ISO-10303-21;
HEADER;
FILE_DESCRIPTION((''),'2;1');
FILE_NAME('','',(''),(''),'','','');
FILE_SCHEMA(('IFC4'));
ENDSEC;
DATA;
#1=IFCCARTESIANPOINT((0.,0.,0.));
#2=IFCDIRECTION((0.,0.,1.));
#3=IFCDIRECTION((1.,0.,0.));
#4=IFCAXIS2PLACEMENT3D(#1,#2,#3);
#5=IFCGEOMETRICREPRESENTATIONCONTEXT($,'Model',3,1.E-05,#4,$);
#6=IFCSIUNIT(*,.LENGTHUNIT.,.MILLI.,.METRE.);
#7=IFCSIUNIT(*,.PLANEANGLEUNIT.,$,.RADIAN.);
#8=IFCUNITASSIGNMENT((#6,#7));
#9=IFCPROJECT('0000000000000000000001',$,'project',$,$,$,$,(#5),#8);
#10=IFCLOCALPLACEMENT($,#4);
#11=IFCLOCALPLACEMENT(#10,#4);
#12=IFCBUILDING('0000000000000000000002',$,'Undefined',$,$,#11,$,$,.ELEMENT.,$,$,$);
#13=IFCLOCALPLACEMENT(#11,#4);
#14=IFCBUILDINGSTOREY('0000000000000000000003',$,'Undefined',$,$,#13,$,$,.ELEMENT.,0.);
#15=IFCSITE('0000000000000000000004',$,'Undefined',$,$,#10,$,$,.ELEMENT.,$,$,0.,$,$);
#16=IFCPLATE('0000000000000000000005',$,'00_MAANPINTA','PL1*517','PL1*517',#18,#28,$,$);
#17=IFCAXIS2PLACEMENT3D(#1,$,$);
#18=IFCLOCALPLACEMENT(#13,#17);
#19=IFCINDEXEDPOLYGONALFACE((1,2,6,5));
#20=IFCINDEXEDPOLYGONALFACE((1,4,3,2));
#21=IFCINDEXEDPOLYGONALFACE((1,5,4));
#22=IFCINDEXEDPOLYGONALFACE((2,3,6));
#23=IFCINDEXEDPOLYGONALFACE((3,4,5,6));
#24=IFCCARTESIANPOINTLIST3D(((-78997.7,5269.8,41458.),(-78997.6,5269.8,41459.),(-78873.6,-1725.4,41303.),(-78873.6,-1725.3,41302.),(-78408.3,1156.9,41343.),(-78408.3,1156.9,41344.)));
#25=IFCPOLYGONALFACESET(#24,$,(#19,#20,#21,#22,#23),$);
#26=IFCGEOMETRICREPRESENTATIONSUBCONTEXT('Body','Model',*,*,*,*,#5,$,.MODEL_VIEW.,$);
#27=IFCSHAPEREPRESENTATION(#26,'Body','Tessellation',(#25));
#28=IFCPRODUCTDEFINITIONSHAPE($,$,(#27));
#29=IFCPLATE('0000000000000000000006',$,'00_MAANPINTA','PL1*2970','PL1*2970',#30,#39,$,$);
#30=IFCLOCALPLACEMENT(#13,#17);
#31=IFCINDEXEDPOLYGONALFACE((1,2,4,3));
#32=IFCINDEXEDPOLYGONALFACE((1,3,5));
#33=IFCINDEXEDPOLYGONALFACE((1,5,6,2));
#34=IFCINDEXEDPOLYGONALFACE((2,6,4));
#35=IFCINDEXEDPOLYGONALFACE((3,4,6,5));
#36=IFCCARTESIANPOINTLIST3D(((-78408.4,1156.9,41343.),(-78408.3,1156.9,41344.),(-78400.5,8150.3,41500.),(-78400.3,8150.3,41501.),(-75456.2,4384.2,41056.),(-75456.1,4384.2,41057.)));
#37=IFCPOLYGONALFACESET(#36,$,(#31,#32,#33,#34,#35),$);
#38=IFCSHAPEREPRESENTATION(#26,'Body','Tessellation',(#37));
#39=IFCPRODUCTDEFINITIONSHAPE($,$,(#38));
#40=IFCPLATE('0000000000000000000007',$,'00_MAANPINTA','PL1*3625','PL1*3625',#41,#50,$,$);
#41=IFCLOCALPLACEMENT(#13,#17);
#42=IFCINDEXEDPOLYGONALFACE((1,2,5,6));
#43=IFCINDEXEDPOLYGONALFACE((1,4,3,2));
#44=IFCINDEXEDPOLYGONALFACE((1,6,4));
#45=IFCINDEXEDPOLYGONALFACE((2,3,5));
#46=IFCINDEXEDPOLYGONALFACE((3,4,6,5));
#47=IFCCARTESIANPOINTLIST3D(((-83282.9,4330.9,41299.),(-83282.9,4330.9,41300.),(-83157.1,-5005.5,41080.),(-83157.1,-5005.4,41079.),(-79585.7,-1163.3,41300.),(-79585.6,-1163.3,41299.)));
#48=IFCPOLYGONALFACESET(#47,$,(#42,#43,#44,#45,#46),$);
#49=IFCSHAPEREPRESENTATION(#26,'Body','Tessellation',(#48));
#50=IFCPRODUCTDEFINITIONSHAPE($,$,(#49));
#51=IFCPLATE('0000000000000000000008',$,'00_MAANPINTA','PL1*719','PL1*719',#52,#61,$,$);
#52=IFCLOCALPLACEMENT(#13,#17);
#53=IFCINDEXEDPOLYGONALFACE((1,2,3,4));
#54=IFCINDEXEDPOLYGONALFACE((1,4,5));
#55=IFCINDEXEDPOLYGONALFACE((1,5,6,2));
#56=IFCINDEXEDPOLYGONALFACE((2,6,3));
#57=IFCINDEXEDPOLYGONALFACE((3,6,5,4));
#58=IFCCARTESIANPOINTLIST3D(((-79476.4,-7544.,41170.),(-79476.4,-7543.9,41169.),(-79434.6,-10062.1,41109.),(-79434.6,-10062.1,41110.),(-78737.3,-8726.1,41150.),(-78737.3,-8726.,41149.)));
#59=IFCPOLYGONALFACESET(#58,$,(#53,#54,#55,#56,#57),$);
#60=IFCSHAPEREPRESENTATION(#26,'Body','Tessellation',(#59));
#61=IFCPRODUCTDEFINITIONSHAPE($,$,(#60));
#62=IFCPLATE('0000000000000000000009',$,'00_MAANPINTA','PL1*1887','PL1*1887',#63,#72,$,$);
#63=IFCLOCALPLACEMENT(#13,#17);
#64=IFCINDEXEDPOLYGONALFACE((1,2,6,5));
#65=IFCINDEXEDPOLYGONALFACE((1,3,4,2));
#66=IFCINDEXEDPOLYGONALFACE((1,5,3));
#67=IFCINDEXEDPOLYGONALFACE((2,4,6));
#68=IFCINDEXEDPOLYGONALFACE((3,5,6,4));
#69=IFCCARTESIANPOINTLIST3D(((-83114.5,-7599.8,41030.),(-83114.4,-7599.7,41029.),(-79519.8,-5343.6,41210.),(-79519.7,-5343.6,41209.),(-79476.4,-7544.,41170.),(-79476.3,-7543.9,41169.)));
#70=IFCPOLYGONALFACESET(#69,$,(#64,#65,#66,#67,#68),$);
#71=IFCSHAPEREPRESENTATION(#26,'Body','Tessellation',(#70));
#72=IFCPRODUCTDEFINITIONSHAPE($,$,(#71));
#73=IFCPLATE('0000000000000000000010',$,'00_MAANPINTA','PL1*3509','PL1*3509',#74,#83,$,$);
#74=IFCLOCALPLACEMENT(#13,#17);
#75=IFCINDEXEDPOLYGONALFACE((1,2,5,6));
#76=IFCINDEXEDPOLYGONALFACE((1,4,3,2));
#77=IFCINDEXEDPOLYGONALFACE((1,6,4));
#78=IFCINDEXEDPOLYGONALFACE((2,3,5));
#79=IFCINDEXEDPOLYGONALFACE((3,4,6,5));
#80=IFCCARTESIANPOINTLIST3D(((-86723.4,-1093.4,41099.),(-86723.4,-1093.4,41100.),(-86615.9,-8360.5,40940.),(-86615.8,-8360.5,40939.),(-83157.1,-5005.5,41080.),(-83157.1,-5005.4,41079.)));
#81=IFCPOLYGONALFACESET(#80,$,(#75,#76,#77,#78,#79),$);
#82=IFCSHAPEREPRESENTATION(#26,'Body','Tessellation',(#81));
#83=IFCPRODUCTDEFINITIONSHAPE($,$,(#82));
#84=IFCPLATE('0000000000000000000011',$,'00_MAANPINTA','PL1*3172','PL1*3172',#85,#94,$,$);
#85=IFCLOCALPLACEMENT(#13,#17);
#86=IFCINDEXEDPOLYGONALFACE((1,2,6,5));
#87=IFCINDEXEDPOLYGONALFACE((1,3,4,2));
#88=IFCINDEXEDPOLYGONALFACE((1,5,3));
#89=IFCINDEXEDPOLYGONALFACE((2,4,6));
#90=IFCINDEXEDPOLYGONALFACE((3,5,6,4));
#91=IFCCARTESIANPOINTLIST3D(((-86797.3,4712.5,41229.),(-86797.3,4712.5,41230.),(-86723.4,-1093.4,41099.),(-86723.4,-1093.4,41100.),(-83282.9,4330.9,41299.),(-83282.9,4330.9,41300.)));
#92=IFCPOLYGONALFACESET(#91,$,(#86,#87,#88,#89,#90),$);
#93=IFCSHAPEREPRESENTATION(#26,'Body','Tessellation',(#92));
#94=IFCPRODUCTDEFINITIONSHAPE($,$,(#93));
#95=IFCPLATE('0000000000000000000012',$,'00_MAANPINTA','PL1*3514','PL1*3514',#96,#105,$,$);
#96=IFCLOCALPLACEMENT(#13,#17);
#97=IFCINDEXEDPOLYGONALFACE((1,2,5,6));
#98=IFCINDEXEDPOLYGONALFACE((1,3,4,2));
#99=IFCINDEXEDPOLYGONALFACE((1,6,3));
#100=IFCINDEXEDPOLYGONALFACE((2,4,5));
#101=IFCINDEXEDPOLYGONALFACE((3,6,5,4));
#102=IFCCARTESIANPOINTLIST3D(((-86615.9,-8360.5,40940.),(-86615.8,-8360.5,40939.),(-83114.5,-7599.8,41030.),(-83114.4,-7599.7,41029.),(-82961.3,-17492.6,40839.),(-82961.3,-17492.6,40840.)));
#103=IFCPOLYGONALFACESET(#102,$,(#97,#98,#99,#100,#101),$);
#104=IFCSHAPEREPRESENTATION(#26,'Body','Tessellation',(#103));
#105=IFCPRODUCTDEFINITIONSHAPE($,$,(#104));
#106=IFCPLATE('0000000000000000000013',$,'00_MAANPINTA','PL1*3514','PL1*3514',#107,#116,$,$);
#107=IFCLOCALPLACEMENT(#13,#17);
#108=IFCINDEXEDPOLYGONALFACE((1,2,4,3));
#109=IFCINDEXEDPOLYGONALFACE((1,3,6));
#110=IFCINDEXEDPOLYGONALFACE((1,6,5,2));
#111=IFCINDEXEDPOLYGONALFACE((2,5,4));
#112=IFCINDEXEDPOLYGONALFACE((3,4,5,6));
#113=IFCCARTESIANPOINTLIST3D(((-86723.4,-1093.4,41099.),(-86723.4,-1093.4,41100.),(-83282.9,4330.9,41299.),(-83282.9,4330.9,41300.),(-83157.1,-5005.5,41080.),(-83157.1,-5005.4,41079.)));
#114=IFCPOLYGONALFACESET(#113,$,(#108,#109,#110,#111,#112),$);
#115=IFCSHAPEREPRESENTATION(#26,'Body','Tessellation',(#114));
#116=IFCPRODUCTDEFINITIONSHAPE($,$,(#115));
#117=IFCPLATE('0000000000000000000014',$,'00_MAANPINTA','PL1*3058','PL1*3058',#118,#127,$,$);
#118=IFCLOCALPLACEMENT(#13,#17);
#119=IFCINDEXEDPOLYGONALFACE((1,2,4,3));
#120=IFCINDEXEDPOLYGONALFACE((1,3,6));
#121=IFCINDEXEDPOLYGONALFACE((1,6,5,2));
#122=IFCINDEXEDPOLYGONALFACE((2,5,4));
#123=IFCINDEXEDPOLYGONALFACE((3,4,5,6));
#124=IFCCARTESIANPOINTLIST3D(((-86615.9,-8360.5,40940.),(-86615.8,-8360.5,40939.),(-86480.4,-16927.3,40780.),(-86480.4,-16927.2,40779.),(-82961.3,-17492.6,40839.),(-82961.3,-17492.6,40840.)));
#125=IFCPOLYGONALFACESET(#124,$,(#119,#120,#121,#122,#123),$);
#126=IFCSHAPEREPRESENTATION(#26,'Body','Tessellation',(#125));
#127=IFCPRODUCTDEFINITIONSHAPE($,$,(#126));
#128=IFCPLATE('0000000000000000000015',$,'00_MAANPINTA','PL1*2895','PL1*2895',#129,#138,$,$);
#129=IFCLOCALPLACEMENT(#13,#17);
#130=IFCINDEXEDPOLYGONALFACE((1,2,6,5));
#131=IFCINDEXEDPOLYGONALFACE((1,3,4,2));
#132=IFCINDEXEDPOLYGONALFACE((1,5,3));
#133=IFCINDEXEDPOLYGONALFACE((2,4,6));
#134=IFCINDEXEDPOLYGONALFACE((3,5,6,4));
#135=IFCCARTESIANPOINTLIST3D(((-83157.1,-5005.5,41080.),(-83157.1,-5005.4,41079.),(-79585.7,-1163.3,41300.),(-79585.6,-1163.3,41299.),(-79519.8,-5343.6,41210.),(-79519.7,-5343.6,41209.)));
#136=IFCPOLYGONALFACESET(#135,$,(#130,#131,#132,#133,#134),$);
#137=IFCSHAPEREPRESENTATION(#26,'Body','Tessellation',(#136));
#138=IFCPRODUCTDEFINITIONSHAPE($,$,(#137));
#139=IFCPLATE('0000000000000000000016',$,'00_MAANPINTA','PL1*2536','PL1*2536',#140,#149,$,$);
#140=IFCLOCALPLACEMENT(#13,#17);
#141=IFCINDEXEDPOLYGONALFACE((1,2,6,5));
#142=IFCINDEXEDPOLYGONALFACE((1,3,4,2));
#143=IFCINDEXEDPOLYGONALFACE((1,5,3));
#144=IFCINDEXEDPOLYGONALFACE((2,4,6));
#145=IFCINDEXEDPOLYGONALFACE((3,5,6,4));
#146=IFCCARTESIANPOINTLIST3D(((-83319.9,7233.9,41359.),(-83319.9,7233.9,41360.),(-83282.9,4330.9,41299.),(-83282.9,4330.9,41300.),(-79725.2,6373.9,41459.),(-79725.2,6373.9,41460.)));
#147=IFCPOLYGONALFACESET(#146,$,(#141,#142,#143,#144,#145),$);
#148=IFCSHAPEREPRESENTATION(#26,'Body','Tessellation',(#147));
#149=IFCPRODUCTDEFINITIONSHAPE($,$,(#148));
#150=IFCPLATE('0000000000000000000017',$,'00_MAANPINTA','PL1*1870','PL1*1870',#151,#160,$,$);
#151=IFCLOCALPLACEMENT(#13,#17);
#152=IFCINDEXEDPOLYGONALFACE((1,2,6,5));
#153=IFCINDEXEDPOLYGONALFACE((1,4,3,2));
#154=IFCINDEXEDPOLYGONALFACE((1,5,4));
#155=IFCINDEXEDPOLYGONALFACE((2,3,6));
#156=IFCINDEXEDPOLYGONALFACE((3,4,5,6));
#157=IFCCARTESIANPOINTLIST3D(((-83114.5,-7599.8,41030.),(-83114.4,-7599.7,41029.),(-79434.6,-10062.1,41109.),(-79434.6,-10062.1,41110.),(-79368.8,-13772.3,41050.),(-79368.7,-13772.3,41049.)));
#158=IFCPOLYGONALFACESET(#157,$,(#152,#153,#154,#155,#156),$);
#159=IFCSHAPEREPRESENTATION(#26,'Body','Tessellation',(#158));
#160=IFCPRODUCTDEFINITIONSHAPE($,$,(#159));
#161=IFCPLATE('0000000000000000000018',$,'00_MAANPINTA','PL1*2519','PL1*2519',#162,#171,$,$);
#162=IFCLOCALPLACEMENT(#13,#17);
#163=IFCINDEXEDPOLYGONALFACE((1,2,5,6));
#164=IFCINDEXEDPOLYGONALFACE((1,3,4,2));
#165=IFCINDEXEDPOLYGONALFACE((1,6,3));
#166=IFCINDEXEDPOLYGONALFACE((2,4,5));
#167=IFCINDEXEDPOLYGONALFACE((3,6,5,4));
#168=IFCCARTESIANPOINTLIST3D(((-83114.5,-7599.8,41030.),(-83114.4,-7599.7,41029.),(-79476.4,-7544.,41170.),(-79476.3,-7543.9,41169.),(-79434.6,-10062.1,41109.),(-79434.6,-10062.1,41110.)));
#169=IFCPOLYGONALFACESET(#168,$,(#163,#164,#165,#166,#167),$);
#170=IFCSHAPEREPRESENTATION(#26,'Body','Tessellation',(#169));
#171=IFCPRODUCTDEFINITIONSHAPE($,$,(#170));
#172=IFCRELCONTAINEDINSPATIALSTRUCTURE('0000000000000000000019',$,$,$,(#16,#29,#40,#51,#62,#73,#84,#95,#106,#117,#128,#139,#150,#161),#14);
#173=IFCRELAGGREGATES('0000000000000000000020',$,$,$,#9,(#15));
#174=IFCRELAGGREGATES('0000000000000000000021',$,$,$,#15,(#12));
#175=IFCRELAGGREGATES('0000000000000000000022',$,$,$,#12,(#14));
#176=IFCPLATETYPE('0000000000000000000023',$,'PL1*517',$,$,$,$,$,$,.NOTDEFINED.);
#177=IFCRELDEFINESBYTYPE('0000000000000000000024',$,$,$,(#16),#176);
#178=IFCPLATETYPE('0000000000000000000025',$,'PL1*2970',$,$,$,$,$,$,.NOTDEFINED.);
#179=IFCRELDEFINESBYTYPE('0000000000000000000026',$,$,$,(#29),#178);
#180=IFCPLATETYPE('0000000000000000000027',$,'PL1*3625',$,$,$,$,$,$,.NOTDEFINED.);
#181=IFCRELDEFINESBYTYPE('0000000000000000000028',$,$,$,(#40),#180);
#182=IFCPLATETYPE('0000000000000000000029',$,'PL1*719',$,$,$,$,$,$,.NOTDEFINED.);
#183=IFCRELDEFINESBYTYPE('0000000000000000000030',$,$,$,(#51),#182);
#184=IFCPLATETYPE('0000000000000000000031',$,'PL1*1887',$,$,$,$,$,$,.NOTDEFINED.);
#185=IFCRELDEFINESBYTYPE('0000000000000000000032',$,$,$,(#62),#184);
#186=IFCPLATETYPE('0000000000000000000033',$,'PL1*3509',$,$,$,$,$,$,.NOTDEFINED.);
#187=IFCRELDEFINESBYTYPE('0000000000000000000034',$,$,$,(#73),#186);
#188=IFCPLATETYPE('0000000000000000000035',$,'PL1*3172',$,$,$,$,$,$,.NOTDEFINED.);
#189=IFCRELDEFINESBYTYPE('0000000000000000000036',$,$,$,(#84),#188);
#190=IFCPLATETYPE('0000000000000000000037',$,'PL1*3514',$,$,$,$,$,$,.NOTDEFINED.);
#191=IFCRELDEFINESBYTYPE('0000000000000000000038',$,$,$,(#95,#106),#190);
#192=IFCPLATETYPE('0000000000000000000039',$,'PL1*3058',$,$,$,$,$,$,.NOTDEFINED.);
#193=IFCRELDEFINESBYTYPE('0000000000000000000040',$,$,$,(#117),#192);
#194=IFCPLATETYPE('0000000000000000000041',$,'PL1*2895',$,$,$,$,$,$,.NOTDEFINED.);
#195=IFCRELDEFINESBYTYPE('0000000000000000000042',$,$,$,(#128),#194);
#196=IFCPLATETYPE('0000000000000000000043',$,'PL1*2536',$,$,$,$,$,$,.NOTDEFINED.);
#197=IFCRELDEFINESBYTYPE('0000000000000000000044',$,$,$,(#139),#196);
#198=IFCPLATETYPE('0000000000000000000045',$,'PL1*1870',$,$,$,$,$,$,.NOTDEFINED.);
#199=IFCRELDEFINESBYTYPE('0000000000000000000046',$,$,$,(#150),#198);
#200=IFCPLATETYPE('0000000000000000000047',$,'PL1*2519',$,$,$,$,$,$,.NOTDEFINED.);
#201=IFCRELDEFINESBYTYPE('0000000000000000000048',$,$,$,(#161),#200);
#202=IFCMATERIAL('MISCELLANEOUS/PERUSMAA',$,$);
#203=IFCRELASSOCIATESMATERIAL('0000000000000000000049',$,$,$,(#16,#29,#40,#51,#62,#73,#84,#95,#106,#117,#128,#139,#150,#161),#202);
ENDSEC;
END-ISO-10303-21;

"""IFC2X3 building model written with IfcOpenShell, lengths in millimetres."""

from ifc_helpers import new_model, si_unit, frame, origin_with_axes, place, context, subcontext, project, spatial, polyline, outline, extrude, material, type_object, element, save


model = new_model("IFC2X3")

# Units and contexts
model_context = context("Model", 3, precision=1e-05, world=origin_with_axes())
body_context = subcontext(model_context, "Body", "Model", "MODEL_VIEW")
ifc_project = project(units=[si_unit("LENGTHUNIT", "METRE", prefix="MILLI"), si_unit("PLANEANGLEUNIT", "RADIAN")], contexts=[model_context])

# Site, building, storey
site_placement = place(None, origin_with_axes())
site = spatial("IfcSite", under=ifc_project, at=site_placement, Name="Undefined", CompositionType="ELEMENT", RefElevation=0.0)
building_placement = place(site_placement, origin_with_axes())
building = spatial("IfcBuilding", under=site, at=building_placement, Name="Undefined", CompositionType="ELEMENT")
storey_placement = place(building_placement, origin_with_axes())
storey = spatial("IfcBuildingStorey", under=building, at=storey_placement, Name="Undefined", CompositionType="ELEMENT", Elevation=0.0)

# Plates
ifc_material = material(Name="MISCELLANEOUS/PERUSMAA")
plate_type_1 = type_object("IfcPlateType", Name="PL1*517", PredefinedType="NOTDEFINED")
plate_1_placement = place(storey_placement, frame((-78873.6, -1725.4, 41302.5), z_axis=(-0.045019, 0.021475, -0.998755), x_axis=(-0.017726, 0.999594, 0.022292)))
element("IfcPlate", 1, at=plate_1_placement, inside=storey, type_object=plate_type_1, material=ifc_material, Name="00_MAANPINTA", Description="PL1*517", ObjectType="PL1*517", context=body_context, shape_type="SweptSolid", body=[
    extrude(outline(polyline([(0.0, 0.0), (6998.0, 0.0), (2873.8, 516.9), (0.0, 0.0)])), frame((0.0, 0.0, -0.5), z_axis=(0.0, 0.0, 1.0), x_axis=(1.0, 0.0, 0.0)), (0.0, 0.0, 1.0), 1.0),
])
plate_type_2 = type_object("IfcPlateType", Name="PL1*2970", PredefinedType="NOTDEFINED")
plate_2_placement = place(storey_placement, frame((-75456.2, 4384.2, 41056.5), z_axis=(-0.120984, 0.022417, -0.992401), x_axis=(-0.673509, -0.736273, 0.065476)))
element("IfcPlate", 2, at=plate_2_placement, inside=storey, type_object=plate_type_2, material=ifc_material, Name="00_MAANPINTA", Description="PL1*2970", ObjectType="PL1*2970", context=body_context, shape_type="SweptSolid", body=[
    extrude(outline(polyline([(0.0, 0.0), (4383.3, 0.0), (-760.9, 4740.3), (0.0, 0.0)])), frame((0.0, 0.0, -0.5), z_axis=(0.0, 0.0, 1.0), x_axis=(1.0, 0.0, 0.0)), (0.0, 0.0, 1.0), 1.0),
])
plate_type_3 = type_object("IfcPlateType", Name="PL1*3625", PredefinedType="NOTDEFINED")
plate_3_placement = place(storey_placement, frame((-83282.9, 4330.9, 41299.5), z_axis=(0.035699, 0.024023, -0.999074), x_axis=(0.558298, -0.829641, 0.0)))
element("IfcPlate", 3, at=plate_3_placement, inside=storey, type_object=plate_type_3, material=ifc_material, Name="00_MAANPINTA", Description="PL1*3625", ObjectType="PL1*3625", context=body_context, shape_type="SweptSolid", body=[
    extrude(outline(polyline([(0.0, 0.0), (6622.4, 0.0), (7816.1, 5112.8), (0.0, 0.0)])), frame((0.0, 0.0, -0.5), z_axis=(0.0, 0.0, 1.0), x_axis=(1.0, 0.0, 0.0)), (0.0, 0.0, 1.0), 1.0),
])
plate_type_4 = type_object("IfcPlateType", Name="PL1*719", PredefinedType="NOTDEFINED")
plate_4_placement = place(storey_placement, frame((-79476.4, -7543.9, 41169.5), z_axis=(0.011346, 0.024007, -0.999647), x_axis=(0.530086, -0.847822, -0.014344)))
element("IfcPlate", 4, at=plate_4_placement, inside=storey, type_object=plate_type_4, material=ifc_material, Name="00_MAANPINTA", Description="PL1*719", ObjectType="PL1*719", context=body_context, shape_type="SweptSolid", body=[
    extrude(outline(polyline([(0.0, 0.0), (1394.3, 0.0), (2157.9, 1299.9), (0.0, 0.0)])), frame((0.0, 0.0, -0.5), z_axis=(0.0, 0.0, 1.0), x_axis=(1.0, 0.0, 0.0)), (0.0, 0.0, 1.0), 1.0),
])
plate_type_5 = type_object("IfcPlateType", Name="PL1*1887", PredefinedType="NOTDEFINED")
plate_5_placement = place(storey_placement, frame((-79519.7, -5343.6, 41209.5), z_axis=(0.038157, 0.018915, -0.999093), x_axis=(0.019718, -0.99964, -0.018172)))
element("IfcPlate", 5, at=plate_5_placement, inside=storey, type_object=plate_type_5, material=ifc_material, Name="00_MAANPINTA", Description="PL1*1887", ObjectType="PL1*1887", context=body_context, shape_type="SweptSolid", body=[
    extrude(outline(polyline([(0.0, 0.0), (2201.1, 0.0), (2187.7, 3641.2), (0.0, 0.0)])), frame((0.0, 0.0, -0.5), z_axis=(0.0, 0.0, 1.0), x_axis=(1.0, 0.0, 0.0)), (0.0, 0.0, 1.0), 1.0),
])
plate_type_6 = type_object("IfcPlateType", Name="PL1*3509", PredefinedType="NOTDEFINED")
plate_6_placement = place(storey_placement, frame((-86615.9, -8360.5, 40939.5), z_axis=(0.018841, 0.022287, -0.999574), x_axis=(-0.014798, 0.999648, 0.022009)))
element("IfcPlate", 6, at=plate_6_placement, inside=storey, type_object=plate_type_6, material=ifc_material, Name="00_MAANPINTA", Description="PL1*3509", ObjectType="PL1*3509", context=body_context, shape_type="SweptSolid", body=[
    extrude(outline(polyline([(0.0, 0.0), (7269.6, 0.0), (3305.7, 3508.7), (0.0, 0.0)])), frame((0.0, 0.0, -0.5), z_axis=(0.0, 0.0, 1.0), x_axis=(1.0, 0.0, 0.0)), (0.0, 0.0, 1.0), 1.0),
])
plate_type_7 = type_object("IfcPlateType", Name="PL1*3172", PredefinedType="NOTDEFINED")
plate_7_placement = place(storey_placement, frame((-86723.4, -1093.4, 41099.5), z_axis=(0.022369, 0.022664, -0.999493), x_axis=(-0.012723, 0.999669, 0.022384)))
element("IfcPlate", 7, at=plate_7_placement, inside=storey, type_object=plate_type_7, material=ifc_material, Name="00_MAANPINTA", Description="PL1*3172", ObjectType="PL1*3172", context=body_context, shape_type="SweptSolid", body=[
    extrude(outline(polyline([(0.0, 0.0), (5807.8, 0.0), (5383.2, 3510.1), (0.0, 0.0)])), frame((0.0, 0.0, -0.5), z_axis=(0.0, 0.0, 1.0), x_axis=(1.0, 0.0, 0.0)), (0.0, 0.0, 1.0), 1.0),
])
plate_type_8 = type_object("IfcPlateType", Name="PL1*3514", PredefinedType="NOTDEFINED")
plate_8_placement = place(storey_placement, frame((-86615.9, -8360.5, 40939.5), z_axis=(0.02145, 0.01953, -0.999579), x_axis=(0.976894, 0.212244, 0.02511)))
element("IfcPlate", 8, at=plate_8_placement, inside=storey, type_object=plate_type_8, material=ifc_material, Name="00_MAANPINTA", Description="PL1*3514", ObjectType="PL1*3514", context=body_context, shape_type="SweptSolid", body=[
    extrude(outline(polyline([(0.0, 0.0), (3584.2, 0.0), (1629.4, 9700.8), (0.0, 0.0)])), frame((0.0, 0.0, -0.5), z_axis=(0.0, 0.0, 1.0), x_axis=(1.0, 0.0, 0.0)), (0.0, 0.0, 1.0), 1.0),
])
plate_9_placement = place(storey_placement, frame((-83282.9, 4330.9, 41299.5), z_axis=(0.020533, 0.023829, -0.999505), x_axis=(0.013474, -0.999632, -0.023555)))
element("IfcPlate", 9, at=plate_9_placement, inside=storey, type_object=plate_type_8, material=ifc_material, Name="00_MAANPINTA", Description="PL1*3514", ObjectType="PL1*3514", context=body_context, shape_type="SweptSolid", body=[
    extrude(outline(polyline([(0.0, 0.0), (9339.8, 0.0), (5380.7, 3514.1), (0.0, 0.0)])), frame((0.0, 0.0, -0.5), z_axis=(0.0, 0.0, 1.0), x_axis=(1.0, 0.0, 0.0)), (0.0, 0.0, 1.0), 1.0),
])
plate_type_9 = type_object("IfcPlateType", Name="PL1*3058", PredefinedType="NOTDEFINED")
plate_10_placement = place(storey_placement, frame((-86615.9, -8360.5, 40939.5), z_axis=(0.020094, 0.018987, -0.999618), x_axis=(0.371524, -0.928368, -0.010166)))
element("IfcPlate", 10, at=plate_10_placement, inside=storey, type_object=plate_type_9, material=ifc_material, Name="00_MAANPINTA", Description="PL1*3058", ObjectType="PL1*3058", context=body_context, shape_type="SweptSolid", body=[
    extrude(outline(polyline([(0.0, 0.0), (9836.7, 0.0), (8005.1, 3058.1), (0.0, 0.0)])), frame((0.0, 0.0, -0.5), z_axis=(0.0, 0.0, 1.0), x_axis=(1.0, 0.0, 0.0)), (0.0, 0.0, 1.0), 1.0),
])
plate_type_10 = type_object("IfcPlateType", Name="PL1*2895", PredefinedType="NOTDEFINED")
plate_11_placement = place(storey_placement, frame((-79585.7, -1163.3, 41299.5), z_axis=(0.037761, 0.022104, -0.999042), x_axis=(0.015762, -0.999644, -0.021522)))
element("IfcPlate", 11, at=plate_11_placement, inside=storey, type_object=plate_type_10, material=ifc_material, Name="00_MAANPINTA", Description="PL1*2895", ObjectType="PL1*2895", context=body_context, shape_type="SweptSolid", body=[
    extrude(outline(polyline([(0.0, 0.0), (4181.8, 0.0), (3789.2, 3634.2), (0.0, 0.0)])), frame((0.0, 0.0, -0.5), z_axis=(0.0, 0.0, 1.0), x_axis=(1.0, 0.0, 0.0)), (0.0, 0.0, 1.0), 1.0),
])
plate_type_11 = type_object("IfcPlateType", Name="PL1*2536", PredefinedType="NOTDEFINED")
plate_12_placement = place(storey_placement, frame((-83282.9, 4330.9, 41299.5), z_axis=(0.032838, 0.021071, -0.999239), x_axis=(-0.012723, 0.999706, 0.020663)))
element("IfcPlate", 12, at=plate_12_placement, inside=storey, type_object=plate_type_11, material=ifc_material, Name="00_MAANPINTA", Description="PL1*2536", ObjectType="PL1*2536", context=body_context, shape_type="SweptSolid", body=[
    extrude(outline(polyline([(0.0, 0.0), (2903.8, 0.0), (2000.4, 3585.4), (0.0, 0.0)])), frame((0.0, 0.0, -0.5), z_axis=(0.0, 0.0, 1.0), x_axis=(1.0, 0.0, 0.0)), (0.0, 0.0, 1.0), 1.0),
])
plate_type_12 = type_object("IfcPlateType", Name="PL1*1870", PredefinedType="NOTDEFINED")
plate_13_placement = place(storey_placement, frame((-83114.4, -7599.8, 41029.5), z_axis=(0.03293, 0.016745, -0.999317), x_axis=(0.830966, -0.556031, 0.018065)))
element("IfcPlate", 13, at=plate_13_placement, inside=storey, type_object=plate_type_12, material=ifc_material, Name="00_MAANPINTA", Description="PL1*1870", ObjectType="PL1*1870", context=body_context, shape_type="SweptSolid", body=[
    extrude(outline(polyline([(0.0, 0.0), (4428.4, 0.0), (6545.0, 3048.5), (0.0, 0.0)])), frame((0.0, 0.0, -0.5), z_axis=(0.0, 0.0, 1.0), x_axis=(1.0, 0.0, 0.0)), (0.0, 0.0, 1.0), 1.0),
])
plate_type_13 = type_object("IfcPlateType", Name="PL1*2519", PredefinedType="NOTDEFINED")
plate_14_placement = place(storey_placement, frame((-79476.3, -7543.9, 41169.5), z_axis=(0.038067, 0.024434, -0.998976), x_axis=(0.016577, -0.999579, -0.023817)))
element("IfcPlate", 14, at=plate_14_placement, inside=storey, type_object=plate_type_13, material=ifc_material, Name="00_MAANPINTA", Description="PL1*2519", ObjectType="PL1*2519", context=body_context, shape_type="SweptSolid", body=[
    extrude(outline(polyline([(0.0, 0.0), (2519.2, 0.0), (-1.2, 3641.2), (0.0, 0.0)])), frame((0.0, 0.0, -0.5), z_axis=(0.0, 0.0, 1.0), x_axis=(1.0, 0.0, 0.0)), (0.0, 0.0, 1.0), 1.0),
])

save(model, "model.ifc")
